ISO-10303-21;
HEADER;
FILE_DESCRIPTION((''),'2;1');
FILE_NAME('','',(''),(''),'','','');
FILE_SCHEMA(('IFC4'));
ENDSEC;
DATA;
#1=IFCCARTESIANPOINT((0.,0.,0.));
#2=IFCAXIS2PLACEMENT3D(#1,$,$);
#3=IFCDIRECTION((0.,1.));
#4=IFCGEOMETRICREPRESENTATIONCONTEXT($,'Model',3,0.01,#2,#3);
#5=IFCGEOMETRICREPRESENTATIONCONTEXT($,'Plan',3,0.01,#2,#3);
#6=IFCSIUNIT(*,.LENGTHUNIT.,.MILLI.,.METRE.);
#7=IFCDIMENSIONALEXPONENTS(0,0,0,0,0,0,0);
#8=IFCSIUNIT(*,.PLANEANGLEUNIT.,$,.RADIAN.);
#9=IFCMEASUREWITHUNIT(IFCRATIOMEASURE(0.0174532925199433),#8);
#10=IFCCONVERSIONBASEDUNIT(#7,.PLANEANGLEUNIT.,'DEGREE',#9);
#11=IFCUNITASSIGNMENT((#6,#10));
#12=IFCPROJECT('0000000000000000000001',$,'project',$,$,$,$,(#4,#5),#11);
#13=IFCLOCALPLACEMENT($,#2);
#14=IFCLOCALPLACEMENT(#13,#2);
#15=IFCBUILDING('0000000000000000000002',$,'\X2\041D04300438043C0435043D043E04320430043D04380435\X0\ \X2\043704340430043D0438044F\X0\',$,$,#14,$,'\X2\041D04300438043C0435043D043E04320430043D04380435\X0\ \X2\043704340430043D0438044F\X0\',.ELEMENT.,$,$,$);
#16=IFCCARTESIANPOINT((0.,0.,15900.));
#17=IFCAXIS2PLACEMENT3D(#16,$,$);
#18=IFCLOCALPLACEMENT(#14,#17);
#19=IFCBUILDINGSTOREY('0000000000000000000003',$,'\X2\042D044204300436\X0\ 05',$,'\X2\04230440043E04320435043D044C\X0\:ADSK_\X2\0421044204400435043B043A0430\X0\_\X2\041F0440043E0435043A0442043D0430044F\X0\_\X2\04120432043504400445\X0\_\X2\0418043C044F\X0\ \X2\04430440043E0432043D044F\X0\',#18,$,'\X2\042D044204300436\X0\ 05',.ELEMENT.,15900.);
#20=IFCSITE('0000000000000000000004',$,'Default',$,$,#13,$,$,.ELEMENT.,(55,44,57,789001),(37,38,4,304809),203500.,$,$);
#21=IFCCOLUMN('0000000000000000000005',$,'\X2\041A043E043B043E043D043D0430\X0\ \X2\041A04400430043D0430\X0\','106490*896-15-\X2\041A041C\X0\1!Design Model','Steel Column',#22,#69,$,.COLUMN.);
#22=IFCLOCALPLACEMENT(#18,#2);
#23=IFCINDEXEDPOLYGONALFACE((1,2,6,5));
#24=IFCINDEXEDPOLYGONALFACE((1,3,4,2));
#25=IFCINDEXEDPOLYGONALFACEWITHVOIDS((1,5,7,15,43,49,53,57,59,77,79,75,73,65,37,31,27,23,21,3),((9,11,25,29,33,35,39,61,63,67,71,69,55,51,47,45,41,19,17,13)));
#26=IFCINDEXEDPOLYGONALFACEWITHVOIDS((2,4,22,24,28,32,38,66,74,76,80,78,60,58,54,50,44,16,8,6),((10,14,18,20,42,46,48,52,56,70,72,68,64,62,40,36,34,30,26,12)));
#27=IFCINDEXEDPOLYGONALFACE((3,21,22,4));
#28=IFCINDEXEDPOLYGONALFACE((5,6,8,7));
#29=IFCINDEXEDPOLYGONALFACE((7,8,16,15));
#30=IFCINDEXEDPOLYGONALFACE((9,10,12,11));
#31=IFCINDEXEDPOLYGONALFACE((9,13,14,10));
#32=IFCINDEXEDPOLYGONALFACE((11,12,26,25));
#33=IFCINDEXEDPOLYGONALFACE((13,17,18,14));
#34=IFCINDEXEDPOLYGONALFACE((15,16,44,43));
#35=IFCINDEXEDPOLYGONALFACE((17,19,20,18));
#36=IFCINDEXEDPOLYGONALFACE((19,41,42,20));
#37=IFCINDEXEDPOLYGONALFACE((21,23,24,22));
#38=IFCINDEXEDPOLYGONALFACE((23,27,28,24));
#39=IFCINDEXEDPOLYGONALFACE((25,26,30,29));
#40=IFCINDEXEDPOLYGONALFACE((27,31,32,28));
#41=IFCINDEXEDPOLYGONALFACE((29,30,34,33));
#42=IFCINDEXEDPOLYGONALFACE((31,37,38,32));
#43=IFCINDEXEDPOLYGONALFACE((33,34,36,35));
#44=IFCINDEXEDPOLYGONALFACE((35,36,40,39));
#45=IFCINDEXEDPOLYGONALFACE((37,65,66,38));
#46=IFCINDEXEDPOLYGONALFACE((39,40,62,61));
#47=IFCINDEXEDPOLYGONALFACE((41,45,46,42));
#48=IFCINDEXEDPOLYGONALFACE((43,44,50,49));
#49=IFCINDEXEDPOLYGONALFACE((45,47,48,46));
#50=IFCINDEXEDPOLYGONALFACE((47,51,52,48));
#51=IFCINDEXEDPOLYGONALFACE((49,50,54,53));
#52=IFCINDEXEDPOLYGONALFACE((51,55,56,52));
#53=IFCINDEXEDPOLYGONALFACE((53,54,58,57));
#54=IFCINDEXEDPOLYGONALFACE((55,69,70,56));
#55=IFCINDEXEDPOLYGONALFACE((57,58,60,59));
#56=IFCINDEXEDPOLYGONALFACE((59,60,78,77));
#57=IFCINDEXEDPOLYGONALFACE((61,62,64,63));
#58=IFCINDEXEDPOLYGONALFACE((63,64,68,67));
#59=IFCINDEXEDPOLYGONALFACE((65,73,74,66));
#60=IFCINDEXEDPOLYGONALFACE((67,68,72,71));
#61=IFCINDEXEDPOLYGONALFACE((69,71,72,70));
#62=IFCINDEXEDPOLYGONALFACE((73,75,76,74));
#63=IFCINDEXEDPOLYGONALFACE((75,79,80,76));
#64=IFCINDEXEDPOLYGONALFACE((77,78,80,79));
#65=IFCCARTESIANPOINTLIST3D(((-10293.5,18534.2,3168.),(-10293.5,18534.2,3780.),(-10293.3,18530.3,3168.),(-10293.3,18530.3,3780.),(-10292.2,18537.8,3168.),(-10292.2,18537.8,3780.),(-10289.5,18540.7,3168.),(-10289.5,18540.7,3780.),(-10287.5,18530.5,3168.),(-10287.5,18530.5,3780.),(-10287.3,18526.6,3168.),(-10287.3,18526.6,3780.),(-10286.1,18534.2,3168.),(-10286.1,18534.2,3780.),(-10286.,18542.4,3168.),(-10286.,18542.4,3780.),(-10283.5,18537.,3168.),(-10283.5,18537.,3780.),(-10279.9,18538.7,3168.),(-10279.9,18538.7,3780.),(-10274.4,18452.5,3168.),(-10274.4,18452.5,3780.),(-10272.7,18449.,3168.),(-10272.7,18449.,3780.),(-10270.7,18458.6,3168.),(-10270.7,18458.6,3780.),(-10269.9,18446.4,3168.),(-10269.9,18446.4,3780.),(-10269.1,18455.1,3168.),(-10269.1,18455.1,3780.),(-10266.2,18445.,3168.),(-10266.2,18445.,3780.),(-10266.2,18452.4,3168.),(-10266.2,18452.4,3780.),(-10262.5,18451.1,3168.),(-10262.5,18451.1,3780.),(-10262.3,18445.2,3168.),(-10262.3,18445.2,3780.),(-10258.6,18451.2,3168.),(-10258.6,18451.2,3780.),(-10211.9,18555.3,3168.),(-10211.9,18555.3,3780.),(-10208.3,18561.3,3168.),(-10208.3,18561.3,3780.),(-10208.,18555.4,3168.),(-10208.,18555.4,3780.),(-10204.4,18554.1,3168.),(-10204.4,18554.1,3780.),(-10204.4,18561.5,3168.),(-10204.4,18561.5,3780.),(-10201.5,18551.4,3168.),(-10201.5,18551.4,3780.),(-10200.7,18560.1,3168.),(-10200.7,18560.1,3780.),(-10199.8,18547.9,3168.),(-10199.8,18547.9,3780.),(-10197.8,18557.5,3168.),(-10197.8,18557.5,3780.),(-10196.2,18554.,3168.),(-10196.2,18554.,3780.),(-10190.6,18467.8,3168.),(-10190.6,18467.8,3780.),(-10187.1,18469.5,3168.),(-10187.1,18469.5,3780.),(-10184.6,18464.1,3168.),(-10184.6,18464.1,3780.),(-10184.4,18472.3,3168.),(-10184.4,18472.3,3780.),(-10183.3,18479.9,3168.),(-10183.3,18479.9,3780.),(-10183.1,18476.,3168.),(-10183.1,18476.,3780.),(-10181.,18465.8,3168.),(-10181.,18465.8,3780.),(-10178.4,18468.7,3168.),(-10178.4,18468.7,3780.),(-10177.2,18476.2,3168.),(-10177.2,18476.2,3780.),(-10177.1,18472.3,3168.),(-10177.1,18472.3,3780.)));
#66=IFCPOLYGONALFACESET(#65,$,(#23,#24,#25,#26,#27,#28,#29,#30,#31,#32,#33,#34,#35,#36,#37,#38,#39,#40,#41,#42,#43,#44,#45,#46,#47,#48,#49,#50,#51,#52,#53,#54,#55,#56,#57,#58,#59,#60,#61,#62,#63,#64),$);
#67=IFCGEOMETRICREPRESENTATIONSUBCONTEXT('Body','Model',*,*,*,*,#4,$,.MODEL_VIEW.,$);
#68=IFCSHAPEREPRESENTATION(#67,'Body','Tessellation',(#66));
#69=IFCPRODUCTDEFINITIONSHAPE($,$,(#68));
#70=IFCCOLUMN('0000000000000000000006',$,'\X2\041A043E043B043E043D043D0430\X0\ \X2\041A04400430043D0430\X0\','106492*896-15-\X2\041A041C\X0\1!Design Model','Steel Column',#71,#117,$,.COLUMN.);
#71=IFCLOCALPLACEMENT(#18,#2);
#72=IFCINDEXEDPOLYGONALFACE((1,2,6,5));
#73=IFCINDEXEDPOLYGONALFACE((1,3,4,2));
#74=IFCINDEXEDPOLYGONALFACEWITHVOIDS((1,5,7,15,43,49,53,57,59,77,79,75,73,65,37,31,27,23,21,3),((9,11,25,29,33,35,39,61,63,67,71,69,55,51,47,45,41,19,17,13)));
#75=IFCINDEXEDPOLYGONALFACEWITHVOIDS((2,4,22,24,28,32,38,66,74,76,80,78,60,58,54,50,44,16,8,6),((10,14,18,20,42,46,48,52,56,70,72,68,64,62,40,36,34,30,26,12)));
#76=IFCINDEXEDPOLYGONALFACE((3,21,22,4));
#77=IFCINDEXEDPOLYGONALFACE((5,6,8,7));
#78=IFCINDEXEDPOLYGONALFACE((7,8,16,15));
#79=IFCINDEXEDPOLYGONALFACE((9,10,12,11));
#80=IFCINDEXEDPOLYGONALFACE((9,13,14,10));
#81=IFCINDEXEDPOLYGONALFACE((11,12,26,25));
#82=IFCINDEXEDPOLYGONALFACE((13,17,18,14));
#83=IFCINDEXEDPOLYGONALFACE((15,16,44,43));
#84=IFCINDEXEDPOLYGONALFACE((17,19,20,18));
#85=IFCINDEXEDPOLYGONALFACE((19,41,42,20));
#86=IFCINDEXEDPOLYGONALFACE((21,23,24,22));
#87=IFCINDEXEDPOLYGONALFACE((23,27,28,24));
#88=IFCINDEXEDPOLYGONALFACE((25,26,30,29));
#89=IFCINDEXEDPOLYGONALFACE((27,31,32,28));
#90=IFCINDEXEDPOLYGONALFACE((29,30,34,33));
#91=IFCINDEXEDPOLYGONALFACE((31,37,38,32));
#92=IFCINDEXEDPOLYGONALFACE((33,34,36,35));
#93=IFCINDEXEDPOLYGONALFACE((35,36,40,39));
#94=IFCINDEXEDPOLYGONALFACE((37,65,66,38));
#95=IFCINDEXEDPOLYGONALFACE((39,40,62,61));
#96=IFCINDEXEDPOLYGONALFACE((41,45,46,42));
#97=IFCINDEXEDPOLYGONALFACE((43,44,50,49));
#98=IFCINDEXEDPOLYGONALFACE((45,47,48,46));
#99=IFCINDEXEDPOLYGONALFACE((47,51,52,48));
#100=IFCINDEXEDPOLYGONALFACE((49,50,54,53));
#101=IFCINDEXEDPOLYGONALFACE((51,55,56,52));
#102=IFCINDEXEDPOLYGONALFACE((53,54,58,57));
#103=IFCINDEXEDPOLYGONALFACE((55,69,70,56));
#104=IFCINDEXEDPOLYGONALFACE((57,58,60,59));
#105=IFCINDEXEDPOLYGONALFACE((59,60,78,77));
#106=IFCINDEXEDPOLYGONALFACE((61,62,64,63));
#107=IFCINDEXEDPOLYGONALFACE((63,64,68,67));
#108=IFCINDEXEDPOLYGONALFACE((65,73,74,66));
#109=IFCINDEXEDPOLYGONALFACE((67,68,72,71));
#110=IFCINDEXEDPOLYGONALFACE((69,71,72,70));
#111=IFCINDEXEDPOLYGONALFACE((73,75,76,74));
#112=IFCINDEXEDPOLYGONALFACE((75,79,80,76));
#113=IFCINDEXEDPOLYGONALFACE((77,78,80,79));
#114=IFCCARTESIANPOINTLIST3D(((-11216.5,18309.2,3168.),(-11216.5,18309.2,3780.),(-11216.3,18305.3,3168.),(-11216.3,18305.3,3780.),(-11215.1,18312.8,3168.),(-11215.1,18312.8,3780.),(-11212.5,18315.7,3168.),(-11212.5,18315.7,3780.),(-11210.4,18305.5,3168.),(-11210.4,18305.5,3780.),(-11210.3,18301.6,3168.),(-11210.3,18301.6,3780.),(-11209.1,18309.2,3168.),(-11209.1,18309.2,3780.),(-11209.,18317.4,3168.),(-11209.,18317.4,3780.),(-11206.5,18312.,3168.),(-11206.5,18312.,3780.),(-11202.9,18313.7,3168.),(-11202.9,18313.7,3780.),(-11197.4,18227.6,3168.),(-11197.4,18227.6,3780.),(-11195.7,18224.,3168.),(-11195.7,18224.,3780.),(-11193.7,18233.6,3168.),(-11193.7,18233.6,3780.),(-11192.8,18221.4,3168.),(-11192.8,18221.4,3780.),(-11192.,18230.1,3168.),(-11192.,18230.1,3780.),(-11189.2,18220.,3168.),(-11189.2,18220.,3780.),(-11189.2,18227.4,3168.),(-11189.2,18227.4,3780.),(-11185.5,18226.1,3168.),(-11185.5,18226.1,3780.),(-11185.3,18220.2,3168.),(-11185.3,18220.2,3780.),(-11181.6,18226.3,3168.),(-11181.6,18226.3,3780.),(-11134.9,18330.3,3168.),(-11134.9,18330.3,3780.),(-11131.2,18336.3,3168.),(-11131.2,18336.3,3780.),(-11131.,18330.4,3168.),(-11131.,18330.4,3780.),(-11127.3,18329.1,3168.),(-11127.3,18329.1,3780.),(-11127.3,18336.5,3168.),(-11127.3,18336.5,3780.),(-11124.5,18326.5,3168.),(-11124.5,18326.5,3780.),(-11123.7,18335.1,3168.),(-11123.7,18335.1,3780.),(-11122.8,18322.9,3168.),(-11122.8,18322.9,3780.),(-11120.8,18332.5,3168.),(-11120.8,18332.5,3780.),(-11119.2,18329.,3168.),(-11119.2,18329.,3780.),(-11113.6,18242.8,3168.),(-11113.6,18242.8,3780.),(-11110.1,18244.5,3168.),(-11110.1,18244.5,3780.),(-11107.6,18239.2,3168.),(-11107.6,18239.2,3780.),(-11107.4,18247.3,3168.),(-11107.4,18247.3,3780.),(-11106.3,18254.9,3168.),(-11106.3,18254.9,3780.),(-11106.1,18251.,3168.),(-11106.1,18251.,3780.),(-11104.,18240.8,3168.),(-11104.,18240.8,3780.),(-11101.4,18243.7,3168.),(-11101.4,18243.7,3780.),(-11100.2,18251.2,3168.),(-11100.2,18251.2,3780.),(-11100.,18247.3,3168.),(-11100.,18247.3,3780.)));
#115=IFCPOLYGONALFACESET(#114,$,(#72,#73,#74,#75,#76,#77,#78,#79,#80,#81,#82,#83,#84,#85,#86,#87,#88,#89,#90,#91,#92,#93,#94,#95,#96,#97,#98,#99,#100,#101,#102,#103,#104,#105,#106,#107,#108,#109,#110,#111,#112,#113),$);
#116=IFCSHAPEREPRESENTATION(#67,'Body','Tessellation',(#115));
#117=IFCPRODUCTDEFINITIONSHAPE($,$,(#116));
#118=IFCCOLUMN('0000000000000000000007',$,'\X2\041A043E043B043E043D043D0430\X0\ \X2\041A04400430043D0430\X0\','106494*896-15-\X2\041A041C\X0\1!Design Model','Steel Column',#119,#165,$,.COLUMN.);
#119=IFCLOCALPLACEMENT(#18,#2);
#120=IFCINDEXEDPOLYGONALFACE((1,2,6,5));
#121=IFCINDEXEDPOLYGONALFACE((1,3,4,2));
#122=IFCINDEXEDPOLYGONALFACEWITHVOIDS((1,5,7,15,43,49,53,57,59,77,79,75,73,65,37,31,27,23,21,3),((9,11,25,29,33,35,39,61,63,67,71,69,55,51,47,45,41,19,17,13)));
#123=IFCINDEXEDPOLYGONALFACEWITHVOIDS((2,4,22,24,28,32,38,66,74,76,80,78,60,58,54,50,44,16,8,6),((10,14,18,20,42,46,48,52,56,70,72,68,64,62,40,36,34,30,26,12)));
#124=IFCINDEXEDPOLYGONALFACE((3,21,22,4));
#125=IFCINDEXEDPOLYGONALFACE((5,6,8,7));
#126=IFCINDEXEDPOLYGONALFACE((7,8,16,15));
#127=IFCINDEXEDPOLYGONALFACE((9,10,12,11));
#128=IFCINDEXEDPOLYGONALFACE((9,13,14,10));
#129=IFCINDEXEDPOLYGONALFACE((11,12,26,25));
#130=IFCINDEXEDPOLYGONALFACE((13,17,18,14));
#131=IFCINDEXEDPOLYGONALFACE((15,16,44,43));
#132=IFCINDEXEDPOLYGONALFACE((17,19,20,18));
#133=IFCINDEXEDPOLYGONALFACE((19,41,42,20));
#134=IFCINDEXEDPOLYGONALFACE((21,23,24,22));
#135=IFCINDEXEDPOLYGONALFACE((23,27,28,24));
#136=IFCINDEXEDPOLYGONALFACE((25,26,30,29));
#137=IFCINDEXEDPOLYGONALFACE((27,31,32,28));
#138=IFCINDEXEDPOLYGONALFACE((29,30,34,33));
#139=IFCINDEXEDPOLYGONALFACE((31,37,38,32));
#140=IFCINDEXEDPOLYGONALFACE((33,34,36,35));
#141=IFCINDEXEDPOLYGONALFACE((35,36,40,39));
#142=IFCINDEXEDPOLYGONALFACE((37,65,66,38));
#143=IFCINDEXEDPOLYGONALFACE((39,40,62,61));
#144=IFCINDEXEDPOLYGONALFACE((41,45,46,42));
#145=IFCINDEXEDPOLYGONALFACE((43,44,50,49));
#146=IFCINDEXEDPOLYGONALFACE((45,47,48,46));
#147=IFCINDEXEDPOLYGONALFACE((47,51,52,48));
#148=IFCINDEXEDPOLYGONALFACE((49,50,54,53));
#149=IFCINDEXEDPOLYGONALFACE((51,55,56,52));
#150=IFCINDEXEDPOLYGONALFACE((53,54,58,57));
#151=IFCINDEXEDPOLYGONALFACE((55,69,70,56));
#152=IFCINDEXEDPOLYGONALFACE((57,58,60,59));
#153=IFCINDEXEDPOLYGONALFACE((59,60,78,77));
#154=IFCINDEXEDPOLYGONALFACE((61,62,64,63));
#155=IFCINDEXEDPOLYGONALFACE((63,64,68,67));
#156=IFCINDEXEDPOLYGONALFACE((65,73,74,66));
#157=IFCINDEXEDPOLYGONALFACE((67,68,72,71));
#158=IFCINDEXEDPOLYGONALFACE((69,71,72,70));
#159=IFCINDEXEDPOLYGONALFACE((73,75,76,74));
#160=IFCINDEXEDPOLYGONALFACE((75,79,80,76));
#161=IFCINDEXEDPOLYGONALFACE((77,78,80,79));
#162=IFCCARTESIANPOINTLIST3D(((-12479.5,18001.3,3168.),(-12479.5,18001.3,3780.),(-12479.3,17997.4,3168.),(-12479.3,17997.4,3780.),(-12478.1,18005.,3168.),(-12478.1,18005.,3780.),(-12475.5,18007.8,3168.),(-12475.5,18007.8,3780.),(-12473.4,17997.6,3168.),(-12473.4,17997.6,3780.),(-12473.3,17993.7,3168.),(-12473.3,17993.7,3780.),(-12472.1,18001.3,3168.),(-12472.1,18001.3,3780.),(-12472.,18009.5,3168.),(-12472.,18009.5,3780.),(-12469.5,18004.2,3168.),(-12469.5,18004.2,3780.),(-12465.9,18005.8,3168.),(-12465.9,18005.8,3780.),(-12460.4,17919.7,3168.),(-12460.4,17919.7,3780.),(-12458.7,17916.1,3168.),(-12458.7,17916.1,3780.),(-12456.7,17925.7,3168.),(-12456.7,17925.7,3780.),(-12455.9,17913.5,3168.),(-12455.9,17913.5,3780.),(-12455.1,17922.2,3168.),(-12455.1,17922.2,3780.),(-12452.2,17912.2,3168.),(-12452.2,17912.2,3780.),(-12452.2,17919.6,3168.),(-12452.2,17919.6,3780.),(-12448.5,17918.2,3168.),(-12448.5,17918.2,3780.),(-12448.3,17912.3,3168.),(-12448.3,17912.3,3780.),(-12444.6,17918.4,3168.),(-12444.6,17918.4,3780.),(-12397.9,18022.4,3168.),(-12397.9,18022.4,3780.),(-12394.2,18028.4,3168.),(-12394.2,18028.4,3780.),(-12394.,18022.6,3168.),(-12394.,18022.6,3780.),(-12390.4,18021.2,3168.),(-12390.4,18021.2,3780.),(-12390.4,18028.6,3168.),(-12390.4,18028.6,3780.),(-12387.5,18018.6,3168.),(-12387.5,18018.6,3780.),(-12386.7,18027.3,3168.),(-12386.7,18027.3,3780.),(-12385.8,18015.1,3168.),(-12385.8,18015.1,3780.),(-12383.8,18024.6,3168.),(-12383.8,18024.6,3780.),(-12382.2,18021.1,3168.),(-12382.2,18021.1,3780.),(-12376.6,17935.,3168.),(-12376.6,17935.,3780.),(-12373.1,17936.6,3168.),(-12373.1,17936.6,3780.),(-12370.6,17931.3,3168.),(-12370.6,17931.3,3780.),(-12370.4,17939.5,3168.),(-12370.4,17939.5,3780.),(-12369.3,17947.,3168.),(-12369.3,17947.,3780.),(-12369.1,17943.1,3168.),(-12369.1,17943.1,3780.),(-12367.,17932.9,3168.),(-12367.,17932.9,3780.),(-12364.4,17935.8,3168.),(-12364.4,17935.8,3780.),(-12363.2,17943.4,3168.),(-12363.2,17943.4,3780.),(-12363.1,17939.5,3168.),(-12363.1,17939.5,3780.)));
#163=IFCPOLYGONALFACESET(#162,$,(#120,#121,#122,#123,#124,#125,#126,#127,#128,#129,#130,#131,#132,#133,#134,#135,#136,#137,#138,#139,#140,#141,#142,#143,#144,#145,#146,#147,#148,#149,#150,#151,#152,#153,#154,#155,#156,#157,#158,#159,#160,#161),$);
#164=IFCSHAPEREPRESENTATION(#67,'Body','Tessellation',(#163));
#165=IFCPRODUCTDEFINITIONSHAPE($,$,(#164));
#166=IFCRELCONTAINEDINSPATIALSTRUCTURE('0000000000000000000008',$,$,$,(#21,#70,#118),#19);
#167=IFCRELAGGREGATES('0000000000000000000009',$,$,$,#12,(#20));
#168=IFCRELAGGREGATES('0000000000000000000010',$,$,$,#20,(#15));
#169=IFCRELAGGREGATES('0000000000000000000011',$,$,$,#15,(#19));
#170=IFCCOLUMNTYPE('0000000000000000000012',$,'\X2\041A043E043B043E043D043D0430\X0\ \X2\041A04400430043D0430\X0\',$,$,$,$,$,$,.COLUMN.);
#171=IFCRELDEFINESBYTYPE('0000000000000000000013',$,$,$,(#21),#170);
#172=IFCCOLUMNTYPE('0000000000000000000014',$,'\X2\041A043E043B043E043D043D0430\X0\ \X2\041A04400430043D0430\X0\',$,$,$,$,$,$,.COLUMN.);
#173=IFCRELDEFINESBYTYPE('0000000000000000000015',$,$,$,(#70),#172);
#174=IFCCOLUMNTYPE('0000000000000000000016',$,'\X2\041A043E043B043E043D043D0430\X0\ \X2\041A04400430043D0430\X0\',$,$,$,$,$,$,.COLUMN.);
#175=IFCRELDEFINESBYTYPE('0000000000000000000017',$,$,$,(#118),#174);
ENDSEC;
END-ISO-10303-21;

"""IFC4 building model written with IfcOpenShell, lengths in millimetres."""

from ifc_helpers import new_model, entity, si_unit, converted_unit, direction, frame, origin, place, context, subcontext, project, spatial, indexed_curve, outline, extrude, type_object, element, save


model = new_model("IFC4")

# Units and contexts
model_context = context("Model", 3, precision=0.01, world=origin(), true_north=direction((0.0, 1.0)))
plan_context = context("Plan", 3, precision=0.01, world=origin(), true_north=direction((0.0, 1.0)))
body_context = subcontext(model_context, "Body", "Model", "MODEL_VIEW")
ifc_project = project(units=[si_unit("LENGTHUNIT", "METRE", prefix="MILLI"), converted_unit("PLANEANGLEUNIT", "DEGREE", entity("IfcRatioMeasure", 0.0174532925199433), si_unit("PLANEANGLEUNIT", "RADIAN"), dimensions=[0, 0, 0, 0, 0, 0, 0])], contexts=[model_context, plan_context])

# Site, building, storey
site_placement = place(None, origin())
site = spatial("IfcSite", under=ifc_project, at=site_placement, Name="Default", CompositionType="ELEMENT", RefLatitude=(55, 44, 57, 789001), RefLongitude=(37, 38, 4, 304809), RefElevation=203500.0)
building_placement = place(site_placement, origin())
building = spatial("IfcBuilding", under=site, at=building_placement, Name="Наименование здания", LongName="Наименование здания", CompositionType="ELEMENT")
storey_placement = place(building_placement, frame((0.0, 0.0, 15900.0)))
storey = spatial("IfcBuildingStorey", under=building, at=storey_placement, Name="Этаж 05", ObjectType="Уровень:ADSK_Стрелка_Проектная_Вверх_Имя уровня", LongName="Этаж 05", CompositionType="ELEMENT", Elevation=15900.0)

# Columns
placement = place(storey_placement, origin())
column_type_1 = type_object("IfcColumnType", Name="Колонна Крана", PredefinedType="COLUMN")
element("IfcColumn", 1, at=placement, inside=storey, type_object=column_type_1, Name="Колонна Крана", Description="106490*896-15-КМ1!Design Model", ObjectType="Steel Column", PredefinedType="COLUMN", context=body_context, shape_type="SweptSolid", body=[
    extrude(outline(indexed_curve([(29.5, -56.8), (33.4, -56.8), (37.0, -55.3), (39.7, -52.6), (41.2, -49.0), (56.8, 29.5), (56.8, 33.4), (55.3, 37.0), (52.6, 39.7), (49.0, 41.2), (-29.5, 56.8), (-33.4, 56.8), (-37.0, 55.3), (-39.7, 52.6), (-41.2, 49.0), (-56.8, -29.5), (-56.8, -33.4), (-55.3, -37.0), (-52.6, -39.7), (-49.0, -41.2), (29.5, -56.8)], self_intersect=False), holes=[indexed_curve([(-43.1, -37.3), (-46.7, -35.8), (-49.5, -33.1), (-51.0, -29.5), (-51.0, -25.5), (-37.3, 43.1), (-35.8, 46.7), (-33.1, 49.5), (-29.5, 51.0), (-25.5, 51.0), (43.1, 37.3), (46.7, 35.8), (49.5, 33.1), (51.0, 29.5), (51.0, 25.5), (37.3, -43.1), (35.8, -46.7), (33.1, -49.5), (29.5, -51.0), (25.5, -51.0), (-43.1, -37.3)], self_intersect=False)]), frame((-10235.3, 18503.2, 3168.0), z_axis=(0.0, 0.0, 1.0), x_axis=(0.906681, 0.421816, 0.0)), (0.0, 0.0, 1.0), 612.0),
])
column_type_2 = type_object("IfcColumnType", Name="Колонна Крана", PredefinedType="COLUMN")
element("IfcColumn", 2, at=placement, inside=storey, type_object=column_type_2, Name="Колонна Крана", Description="106492*896-15-КМ1!Design Model", ObjectType="Steel Column", PredefinedType="COLUMN", context=body_context, shape_type="SweptSolid", body=[
    extrude(outline(indexed_curve([(29.5, -56.8), (33.4, -56.8), (37.0, -55.3), (39.7, -52.6), (41.2, -49.0), (56.8, 29.5), (56.8, 33.4), (55.3, 37.0), (52.6, 39.7), (49.0, 41.2), (-29.5, 56.8), (-33.4, 56.8), (-37.0, 55.3), (-39.7, 52.6), (-41.2, 49.0), (-56.8, -29.5), (-56.8, -33.4), (-55.3, -37.0), (-52.6, -39.7), (-49.0, -41.2), (29.5, -56.8)], self_intersect=False), holes=[indexed_curve([(-43.1, -37.3), (-46.7, -35.8), (-49.5, -33.1), (-51.0, -29.5), (-51.0, -25.5), (-37.3, 43.1), (-35.8, 46.7), (-33.1, 49.5), (-29.5, 51.0), (-25.5, 51.0), (43.1, 37.3), (46.7, 35.8), (49.5, 33.1), (51.0, 29.5), (51.0, 25.5), (37.3, -43.1), (35.8, -46.7), (33.1, -49.5), (29.5, -51.0), (25.5, -51.0), (-43.1, -37.3)], self_intersect=False)]), frame((-11158.3, 18278.3, 3168.0), z_axis=(0.0, 0.0, 1.0), x_axis=(0.906681, 0.421816, 0.0)), (0.0, 0.0, 1.0), 612.0),
])
column_type_3 = type_object("IfcColumnType", Name="Колонна Крана", PredefinedType="COLUMN")
element("IfcColumn", 3, at=placement, inside=storey, type_object=column_type_3, Name="Колонна Крана", Description="106494*896-15-КМ1!Design Model", ObjectType="Steel Column", PredefinedType="COLUMN", context=body_context, shape_type="SweptSolid", body=[
    extrude(outline(indexed_curve([(29.5, -56.8), (33.4, -56.8), (37.0, -55.3), (39.7, -52.6), (41.2, -49.0), (56.8, 29.5), (56.8, 33.4), (55.3, 37.0), (52.6, 39.7), (49.0, 41.2), (-29.5, 56.8), (-33.4, 56.8), (-37.0, 55.3), (-39.7, 52.6), (-41.2, 49.0), (-56.8, -29.5), (-56.8, -33.4), (-55.3, -37.0), (-52.6, -39.7), (-49.0, -41.2), (29.5, -56.8)], self_intersect=False), holes=[indexed_curve([(-43.1, -37.3), (-46.7, -35.8), (-49.5, -33.1), (-51.0, -29.5), (-51.0, -25.5), (-37.3, 43.1), (-35.8, 46.7), (-33.1, 49.5), (-29.5, 51.0), (-25.5, 51.0), (43.1, 37.3), (46.7, 35.8), (49.5, 33.1), (51.0, 29.5), (51.0, 25.5), (37.3, -43.1), (35.8, -46.7), (33.1, -49.5), (29.5, -51.0), (25.5, -51.0), (-43.1, -37.3)], self_intersect=False)]), frame((-12421.3, 17970.4, 3168.0), z_axis=(0.0, 0.0, 1.0), x_axis=(0.906681, 0.421816, 0.0)), (0.0, 0.0, 1.0), 612.0),
])

save(model, "model.ifc")
